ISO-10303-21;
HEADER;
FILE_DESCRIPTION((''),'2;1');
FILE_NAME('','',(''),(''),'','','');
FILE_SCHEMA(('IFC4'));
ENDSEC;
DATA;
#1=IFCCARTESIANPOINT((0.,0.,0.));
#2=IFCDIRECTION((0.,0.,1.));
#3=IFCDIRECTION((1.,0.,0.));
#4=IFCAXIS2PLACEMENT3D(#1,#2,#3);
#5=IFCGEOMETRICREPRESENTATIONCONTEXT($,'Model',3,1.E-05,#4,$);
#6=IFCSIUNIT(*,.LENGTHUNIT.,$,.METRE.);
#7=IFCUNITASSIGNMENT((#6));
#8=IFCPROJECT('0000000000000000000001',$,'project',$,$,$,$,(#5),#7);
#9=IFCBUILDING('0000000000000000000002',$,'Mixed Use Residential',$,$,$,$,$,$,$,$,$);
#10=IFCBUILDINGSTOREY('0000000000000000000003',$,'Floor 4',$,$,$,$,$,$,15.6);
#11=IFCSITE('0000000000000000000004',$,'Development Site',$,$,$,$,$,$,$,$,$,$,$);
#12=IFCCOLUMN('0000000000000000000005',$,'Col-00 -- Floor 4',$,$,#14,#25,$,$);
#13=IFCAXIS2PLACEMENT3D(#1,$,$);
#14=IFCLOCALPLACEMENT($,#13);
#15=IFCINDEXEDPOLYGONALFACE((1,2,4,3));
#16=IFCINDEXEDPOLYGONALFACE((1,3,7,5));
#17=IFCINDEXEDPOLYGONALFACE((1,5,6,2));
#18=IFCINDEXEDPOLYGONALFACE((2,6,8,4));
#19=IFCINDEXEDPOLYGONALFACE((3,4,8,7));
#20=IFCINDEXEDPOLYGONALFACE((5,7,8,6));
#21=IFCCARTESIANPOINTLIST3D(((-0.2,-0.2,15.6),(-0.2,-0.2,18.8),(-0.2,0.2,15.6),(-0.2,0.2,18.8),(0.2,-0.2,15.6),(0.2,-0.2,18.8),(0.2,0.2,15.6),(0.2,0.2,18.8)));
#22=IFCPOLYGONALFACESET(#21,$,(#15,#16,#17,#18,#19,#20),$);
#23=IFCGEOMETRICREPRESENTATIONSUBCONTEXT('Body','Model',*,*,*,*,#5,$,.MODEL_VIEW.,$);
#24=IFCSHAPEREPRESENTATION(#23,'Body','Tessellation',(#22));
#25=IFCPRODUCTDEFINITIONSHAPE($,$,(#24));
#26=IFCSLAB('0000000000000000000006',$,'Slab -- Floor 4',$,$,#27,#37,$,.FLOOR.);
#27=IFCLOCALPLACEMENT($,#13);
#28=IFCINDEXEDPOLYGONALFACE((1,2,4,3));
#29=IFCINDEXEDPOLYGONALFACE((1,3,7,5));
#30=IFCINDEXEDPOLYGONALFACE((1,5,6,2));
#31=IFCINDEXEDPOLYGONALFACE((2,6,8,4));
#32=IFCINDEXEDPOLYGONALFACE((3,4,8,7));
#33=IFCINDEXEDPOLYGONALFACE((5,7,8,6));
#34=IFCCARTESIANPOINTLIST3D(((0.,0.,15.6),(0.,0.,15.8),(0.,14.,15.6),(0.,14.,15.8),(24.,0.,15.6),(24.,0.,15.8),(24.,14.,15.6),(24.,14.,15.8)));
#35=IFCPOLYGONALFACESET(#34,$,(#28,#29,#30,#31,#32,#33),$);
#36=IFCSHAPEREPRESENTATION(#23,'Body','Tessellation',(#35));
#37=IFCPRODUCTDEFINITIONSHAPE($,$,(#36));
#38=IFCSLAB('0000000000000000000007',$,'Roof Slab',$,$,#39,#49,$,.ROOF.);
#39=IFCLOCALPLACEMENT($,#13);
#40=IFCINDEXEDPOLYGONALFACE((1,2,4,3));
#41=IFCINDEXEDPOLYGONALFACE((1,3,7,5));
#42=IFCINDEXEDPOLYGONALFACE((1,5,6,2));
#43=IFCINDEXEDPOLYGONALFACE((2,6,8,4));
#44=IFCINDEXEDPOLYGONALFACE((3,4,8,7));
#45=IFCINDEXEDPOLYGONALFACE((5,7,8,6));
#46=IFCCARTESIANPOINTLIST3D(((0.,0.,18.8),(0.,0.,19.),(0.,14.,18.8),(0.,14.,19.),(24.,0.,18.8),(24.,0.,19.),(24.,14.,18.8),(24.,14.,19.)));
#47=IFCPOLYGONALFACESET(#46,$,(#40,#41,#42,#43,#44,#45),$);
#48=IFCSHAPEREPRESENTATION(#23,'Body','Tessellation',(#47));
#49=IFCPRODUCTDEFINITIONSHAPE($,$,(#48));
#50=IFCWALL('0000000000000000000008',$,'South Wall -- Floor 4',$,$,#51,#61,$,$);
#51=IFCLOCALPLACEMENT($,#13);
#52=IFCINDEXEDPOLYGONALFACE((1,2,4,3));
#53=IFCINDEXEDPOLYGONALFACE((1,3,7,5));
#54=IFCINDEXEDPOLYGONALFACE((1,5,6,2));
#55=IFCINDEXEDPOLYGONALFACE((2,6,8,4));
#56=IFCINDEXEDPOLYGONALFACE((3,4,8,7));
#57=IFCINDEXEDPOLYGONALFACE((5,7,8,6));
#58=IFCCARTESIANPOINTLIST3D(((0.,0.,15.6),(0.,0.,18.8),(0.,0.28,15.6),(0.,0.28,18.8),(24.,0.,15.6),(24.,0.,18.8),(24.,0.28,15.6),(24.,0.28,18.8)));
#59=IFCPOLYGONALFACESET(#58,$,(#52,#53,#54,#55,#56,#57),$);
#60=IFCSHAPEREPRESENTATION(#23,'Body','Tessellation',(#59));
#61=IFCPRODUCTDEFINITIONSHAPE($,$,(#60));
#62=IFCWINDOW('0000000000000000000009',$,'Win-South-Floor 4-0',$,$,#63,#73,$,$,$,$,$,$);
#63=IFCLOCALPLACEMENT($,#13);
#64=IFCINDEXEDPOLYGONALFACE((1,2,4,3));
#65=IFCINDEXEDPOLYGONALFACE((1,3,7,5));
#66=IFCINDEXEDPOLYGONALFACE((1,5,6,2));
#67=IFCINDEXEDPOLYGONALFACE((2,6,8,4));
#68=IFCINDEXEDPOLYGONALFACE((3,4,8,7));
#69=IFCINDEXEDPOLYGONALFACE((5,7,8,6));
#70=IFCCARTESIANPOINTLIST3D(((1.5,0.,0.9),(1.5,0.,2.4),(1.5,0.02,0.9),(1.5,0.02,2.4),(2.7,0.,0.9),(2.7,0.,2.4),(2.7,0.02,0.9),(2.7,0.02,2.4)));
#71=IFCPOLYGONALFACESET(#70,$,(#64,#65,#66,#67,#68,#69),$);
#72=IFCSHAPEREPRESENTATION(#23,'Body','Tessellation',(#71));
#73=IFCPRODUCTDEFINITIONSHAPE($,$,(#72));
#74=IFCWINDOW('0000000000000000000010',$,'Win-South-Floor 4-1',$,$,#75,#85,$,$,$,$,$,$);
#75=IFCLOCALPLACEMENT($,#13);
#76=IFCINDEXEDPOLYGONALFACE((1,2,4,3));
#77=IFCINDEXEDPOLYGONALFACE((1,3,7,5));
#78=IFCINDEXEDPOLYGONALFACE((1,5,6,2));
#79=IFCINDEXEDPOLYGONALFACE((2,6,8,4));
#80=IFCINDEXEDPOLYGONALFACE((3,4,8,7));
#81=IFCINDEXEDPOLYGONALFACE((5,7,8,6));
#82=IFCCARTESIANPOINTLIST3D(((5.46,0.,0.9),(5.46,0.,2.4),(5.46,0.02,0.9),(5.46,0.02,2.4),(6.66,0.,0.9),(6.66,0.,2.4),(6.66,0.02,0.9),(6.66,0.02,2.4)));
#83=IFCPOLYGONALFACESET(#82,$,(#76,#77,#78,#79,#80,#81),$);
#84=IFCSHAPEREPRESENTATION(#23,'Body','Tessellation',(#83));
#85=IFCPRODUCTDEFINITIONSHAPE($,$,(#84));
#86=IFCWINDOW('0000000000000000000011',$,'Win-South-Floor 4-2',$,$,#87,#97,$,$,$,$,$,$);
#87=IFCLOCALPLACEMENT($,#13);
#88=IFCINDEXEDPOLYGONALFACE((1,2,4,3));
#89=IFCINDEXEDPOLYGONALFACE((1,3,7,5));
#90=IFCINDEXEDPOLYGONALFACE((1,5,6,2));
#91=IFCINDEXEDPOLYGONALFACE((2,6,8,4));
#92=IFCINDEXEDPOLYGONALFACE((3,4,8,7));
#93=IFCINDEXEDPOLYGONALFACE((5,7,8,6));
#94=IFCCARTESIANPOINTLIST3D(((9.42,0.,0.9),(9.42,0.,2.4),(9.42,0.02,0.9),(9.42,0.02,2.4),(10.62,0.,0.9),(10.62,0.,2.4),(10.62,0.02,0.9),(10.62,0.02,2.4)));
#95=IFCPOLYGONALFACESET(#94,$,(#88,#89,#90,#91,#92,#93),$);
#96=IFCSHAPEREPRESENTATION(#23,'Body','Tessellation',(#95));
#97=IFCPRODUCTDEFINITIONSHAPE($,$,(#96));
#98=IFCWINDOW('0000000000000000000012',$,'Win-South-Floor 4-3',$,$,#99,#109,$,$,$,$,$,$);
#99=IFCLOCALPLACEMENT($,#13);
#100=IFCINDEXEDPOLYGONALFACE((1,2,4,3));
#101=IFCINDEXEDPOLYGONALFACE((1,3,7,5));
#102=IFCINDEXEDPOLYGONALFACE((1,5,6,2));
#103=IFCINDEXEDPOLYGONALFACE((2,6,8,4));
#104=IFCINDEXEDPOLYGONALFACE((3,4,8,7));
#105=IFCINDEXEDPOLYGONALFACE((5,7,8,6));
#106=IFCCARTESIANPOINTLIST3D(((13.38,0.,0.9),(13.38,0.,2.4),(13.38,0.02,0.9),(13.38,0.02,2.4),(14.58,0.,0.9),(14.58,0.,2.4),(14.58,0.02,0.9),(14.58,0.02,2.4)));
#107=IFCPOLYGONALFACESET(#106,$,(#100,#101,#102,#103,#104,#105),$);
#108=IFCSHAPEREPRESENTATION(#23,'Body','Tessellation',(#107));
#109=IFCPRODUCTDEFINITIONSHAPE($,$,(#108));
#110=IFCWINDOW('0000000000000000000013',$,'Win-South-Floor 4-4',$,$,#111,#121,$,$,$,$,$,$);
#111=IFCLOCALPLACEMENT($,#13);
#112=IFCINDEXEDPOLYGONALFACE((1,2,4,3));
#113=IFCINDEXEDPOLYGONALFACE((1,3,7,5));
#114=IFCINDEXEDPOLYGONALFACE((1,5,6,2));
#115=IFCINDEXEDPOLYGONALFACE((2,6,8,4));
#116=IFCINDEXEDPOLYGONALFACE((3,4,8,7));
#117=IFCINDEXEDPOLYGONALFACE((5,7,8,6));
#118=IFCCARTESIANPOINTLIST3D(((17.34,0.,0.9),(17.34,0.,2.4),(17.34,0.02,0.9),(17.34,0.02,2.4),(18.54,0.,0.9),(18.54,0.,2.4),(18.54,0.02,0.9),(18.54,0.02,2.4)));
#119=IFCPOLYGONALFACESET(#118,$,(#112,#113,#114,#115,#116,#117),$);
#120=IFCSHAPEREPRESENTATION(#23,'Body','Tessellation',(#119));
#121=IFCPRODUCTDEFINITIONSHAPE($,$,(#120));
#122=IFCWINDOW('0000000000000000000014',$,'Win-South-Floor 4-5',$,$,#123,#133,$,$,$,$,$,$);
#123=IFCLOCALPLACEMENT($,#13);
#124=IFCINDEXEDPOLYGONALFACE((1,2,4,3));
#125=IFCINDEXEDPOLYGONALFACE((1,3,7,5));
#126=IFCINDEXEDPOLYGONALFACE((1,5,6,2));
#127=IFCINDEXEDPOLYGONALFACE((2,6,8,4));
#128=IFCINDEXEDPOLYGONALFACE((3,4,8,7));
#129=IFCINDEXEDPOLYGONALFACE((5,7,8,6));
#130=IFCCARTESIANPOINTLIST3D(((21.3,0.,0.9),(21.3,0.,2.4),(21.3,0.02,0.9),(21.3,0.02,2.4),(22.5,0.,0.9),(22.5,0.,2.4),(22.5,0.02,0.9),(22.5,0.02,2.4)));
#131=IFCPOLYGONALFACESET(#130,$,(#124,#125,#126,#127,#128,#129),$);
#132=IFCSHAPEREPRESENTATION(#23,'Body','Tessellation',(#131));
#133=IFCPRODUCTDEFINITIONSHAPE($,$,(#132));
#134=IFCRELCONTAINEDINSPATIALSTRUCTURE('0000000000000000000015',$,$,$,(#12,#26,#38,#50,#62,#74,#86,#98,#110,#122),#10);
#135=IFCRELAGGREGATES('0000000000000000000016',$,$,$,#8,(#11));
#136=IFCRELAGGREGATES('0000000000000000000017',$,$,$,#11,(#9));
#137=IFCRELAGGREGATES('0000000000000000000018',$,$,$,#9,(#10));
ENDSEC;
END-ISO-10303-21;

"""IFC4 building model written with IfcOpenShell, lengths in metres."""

from ifc_helpers import new_model, si_unit, frame, origin_with_axes, place, context, subcontext, project, spatial, indexed_curve, rectangle, outline, extrude, element, fill, save


model = new_model("IFC4")

# Units and contexts
model_context = context("Model", 3, precision=1e-05, world=origin_with_axes())
body_context = subcontext(model_context, "Body", "Model", "MODEL_VIEW")
ifc_project = project(units=[si_unit("LENGTHUNIT", "METRE")], contexts=[model_context])

# Site, building, storey
site = spatial("IfcSite", under=ifc_project, Name="Development Site")
building = spatial("IfcBuilding", under=site, Name="Mixed Use Residential")
storey = spatial("IfcBuildingStorey", under=building, Name="Floor 4", Elevation=15.6)

# Column
column_placement = place(None, frame((0.0, 0.0, 15.6), z_axis=(0.0, 0.0, 1.0), x_axis=(1.0, 0.0, 0.0)))
element("IfcColumn", 1, at=column_placement, inside=storey, Name="Col-00 -- Floor 4", context=body_context, shape_type="SweptSolid", body=[
    extrude(rectangle(XDim=0.4, YDim=0.4), origin_with_axes(), (0.0, 0.0, 1.0), 3.2),
])

# Slabs
slab_1_placement = place(None, frame((0.0, 0.0, 15.6), z_axis=(0.0, 0.0, 1.0), x_axis=(1.0, 0.0, 0.0)))
element("IfcSlab", 2, at=slab_1_placement, inside=storey, Name="Slab -- Floor 4", PredefinedType="FLOOR", context=body_context, shape_type="SweptSolid", body=[
    extrude(outline(indexed_curve([(0.0, 0.0), (24.0, 0.0), (24.0, 14.0), (0.0, 14.0), (0.0, 0.0)])), None, (0.0, 0.0, 1.0), 0.2),
])
slab_2_placement = place(None, frame((0.0, 0.0, 18.8), z_axis=(0.0, 0.0, 1.0), x_axis=(1.0, 0.0, 0.0)))
element("IfcSlab", 3, at=slab_2_placement, inside=storey, Name="Roof Slab", PredefinedType="ROOF", context=body_context, shape_type="SweptSolid", body=[
    extrude(outline(indexed_curve([(0.0, 0.0), (24.0, 0.0), (24.0, 14.0), (0.0, 14.0), (0.0, 0.0)])), None, (0.0, 0.0, 1.0), 0.2),
])

# Wall, openings, windows
wall_1_placement = place(None, frame((0.0, 0.0, 15.6), z_axis=(0.0, 0.0, 1.0), x_axis=(1.0, 0.0, 0.0)))
wall_1 = element("IfcWall", 4, at=wall_1_placement, inside=storey, Name="South Wall -- Floor 4", context=body_context, shape_type="SweptSolid", body=[
    extrude(outline(indexed_curve([(0.0, 0.0), (0.0, 0.28), (24.0, 0.28), (24.0, 0.0), (0.0, 0.0)], self_intersect=False)), origin_with_axes(), (0.0, 0.0, 1.0), 3.2),
])
opening_1_placement = place(wall_1_placement, frame((1.5, 0.0, -14.7), z_axis=(0.0, 0.0, 1.0), x_axis=(1.0, 0.0, 0.0)))
opening_1 = element("IfcOpeningElement", 5, at=opening_1_placement, cuts=wall_1, context=body_context, shape_type="SweptSolid", body=[
    extrude(outline(indexed_curve([(0.0, 0.0), (0.0, 0.28), (1.2, 0.28), (1.2, 0.0), (0.0, 0.0)], self_intersect=False)), origin_with_axes(), (0.0, 0.0, 1.0), 1.5),
])
opening_2_placement = place(wall_1_placement, frame((5.46, 0.0, -14.7), z_axis=(0.0, 0.0, 1.0), x_axis=(1.0, 0.0, 0.0)))
opening_2 = element("IfcOpeningElement", 6, at=opening_2_placement, cuts=wall_1, context=body_context, shape_type="SweptSolid", body=[
    extrude(outline(indexed_curve([(0.0, 0.0), (0.0, 0.28), (1.2, 0.28), (1.2, 0.0), (0.0, 0.0)], self_intersect=False)), origin_with_axes(), (0.0, 0.0, 1.0), 1.5),
])
opening_3_placement = place(wall_1_placement, frame((9.42, 0.0, -14.7), z_axis=(0.0, 0.0, 1.0), x_axis=(1.0, 0.0, 0.0)))
opening_3 = element("IfcOpeningElement", 7, at=opening_3_placement, cuts=wall_1, context=body_context, shape_type="SweptSolid", body=[
    extrude(outline(indexed_curve([(0.0, 0.0), (0.0, 0.28), (1.2, 0.28), (1.2, 0.0), (0.0, 0.0)], self_intersect=False)), origin_with_axes(), (0.0, 0.0, 1.0), 1.5),
])
opening_4_placement = place(wall_1_placement, frame((13.38, 0.0, -14.7), z_axis=(0.0, 0.0, 1.0), x_axis=(1.0, 0.0, 0.0)))
opening_4 = element("IfcOpeningElement", 8, at=opening_4_placement, cuts=wall_1, context=body_context, shape_type="SweptSolid", body=[
    extrude(outline(indexed_curve([(0.0, 0.0), (0.0, 0.28), (1.2, 0.28), (1.2, 0.0), (0.0, 0.0)], self_intersect=False)), origin_with_axes(), (0.0, 0.0, 1.0), 1.5),
])
opening_5_placement = place(wall_1_placement, frame((17.34, 0.0, -14.7), z_axis=(0.0, 0.0, 1.0), x_axis=(1.0, 0.0, 0.0)))
opening_5 = element("IfcOpeningElement", 9, at=opening_5_placement, cuts=wall_1, context=body_context, shape_type="SweptSolid", body=[
    extrude(outline(indexed_curve([(0.0, 0.0), (0.0, 0.28), (1.2, 0.28), (1.2, 0.0), (0.0, 0.0)], self_intersect=False)), origin_with_axes(), (0.0, 0.0, 1.0), 1.5),
])
opening_6_placement = place(wall_1_placement, frame((21.3, 0.0, -14.7), z_axis=(0.0, 0.0, 1.0), x_axis=(1.0, 0.0, 0.0)))
opening_6 = element("IfcOpeningElement", 10, at=opening_6_placement, cuts=wall_1, context=body_context, shape_type="SweptSolid", body=[
    extrude(outline(indexed_curve([(0.0, 0.0), (0.0, 0.28), (1.2, 0.28), (1.2, 0.0), (0.0, 0.0)], self_intersect=False)), origin_with_axes(), (0.0, 0.0, 1.0), 1.5),
])
window_1_placement = place(None, frame((1.5, 0.0, 0.9), z_axis=(0.0, 0.0, 1.0), x_axis=(1.0, 0.0, 0.0)))
window_1 = element("IfcWindow", 11, at=window_1_placement, inside=storey, Name="Win-South-Floor 4-0", context=body_context, shape_type="SweptSolid", body=[
    extrude(outline(indexed_curve([(0.0, 0.0), (0.0, 0.02), (1.2, 0.02), (1.2, 0.0), (0.0, 0.0)], self_intersect=False)), origin_with_axes(), (0.0, 0.0, 1.0), 1.5),
])
fill(opening_1, window_1)
window_2_placement = place(None, frame((5.46, 0.0, 0.9), z_axis=(0.0, 0.0, 1.0), x_axis=(1.0, 0.0, 0.0)))
window_2 = element("IfcWindow", 12, at=window_2_placement, inside=storey, Name="Win-South-Floor 4-1", context=body_context, shape_type="SweptSolid", body=[
    extrude(outline(indexed_curve([(0.0, 0.0), (0.0, 0.02), (1.2, 0.02), (1.2, 0.0), (0.0, 0.0)], self_intersect=False)), origin_with_axes(), (0.0, 0.0, 1.0), 1.5),
])
fill(opening_2, window_2)
window_3_placement = place(None, frame((9.42, 0.0, 0.9), z_axis=(0.0, 0.0, 1.0), x_axis=(1.0, 0.0, 0.0)))
window_3 = element("IfcWindow", 13, at=window_3_placement, inside=storey, Name="Win-South-Floor 4-2", context=body_context, shape_type="SweptSolid", body=[
    extrude(outline(indexed_curve([(0.0, 0.0), (0.0, 0.02), (1.2, 0.02), (1.2, 0.0), (0.0, 0.0)], self_intersect=False)), origin_with_axes(), (0.0, 0.0, 1.0), 1.5),
])
fill(opening_3, window_3)
window_4_placement = place(None, frame((13.38, 0.0, 0.9), z_axis=(0.0, 0.0, 1.0), x_axis=(1.0, 0.0, 0.0)))
window_4 = element("IfcWindow", 14, at=window_4_placement, inside=storey, Name="Win-South-Floor 4-3", context=body_context, shape_type="SweptSolid", body=[
    extrude(outline(indexed_curve([(0.0, 0.0), (0.0, 0.02), (1.2, 0.02), (1.2, 0.0), (0.0, 0.0)], self_intersect=False)), origin_with_axes(), (0.0, 0.0, 1.0), 1.5),
])
fill(opening_4, window_4)
window_5_placement = place(None, frame((17.34, 0.0, 0.9), z_axis=(0.0, 0.0, 1.0), x_axis=(1.0, 0.0, 0.0)))
window_5 = element("IfcWindow", 15, at=window_5_placement, inside=storey, Name="Win-South-Floor 4-4", context=body_context, shape_type="SweptSolid", body=[
    extrude(outline(indexed_curve([(0.0, 0.0), (0.0, 0.02), (1.2, 0.02), (1.2, 0.0), (0.0, 0.0)], self_intersect=False)), origin_with_axes(), (0.0, 0.0, 1.0), 1.5),
])
fill(opening_5, window_5)
window_6_placement = place(None, frame((21.3, 0.0, 0.9), z_axis=(0.0, 0.0, 1.0), x_axis=(1.0, 0.0, 0.0)))
window_6 = element("IfcWindow", 16, at=window_6_placement, inside=storey, Name="Win-South-Floor 4-5", context=body_context, shape_type="SweptSolid", body=[
    extrude(outline(indexed_curve([(0.0, 0.0), (0.0, 0.02), (1.2, 0.02), (1.2, 0.0), (0.0, 0.0)], self_intersect=False)), origin_with_axes(), (0.0, 0.0, 1.0), 1.5),
])
fill(opening_6, window_6)

save(model, "model.ifc")
